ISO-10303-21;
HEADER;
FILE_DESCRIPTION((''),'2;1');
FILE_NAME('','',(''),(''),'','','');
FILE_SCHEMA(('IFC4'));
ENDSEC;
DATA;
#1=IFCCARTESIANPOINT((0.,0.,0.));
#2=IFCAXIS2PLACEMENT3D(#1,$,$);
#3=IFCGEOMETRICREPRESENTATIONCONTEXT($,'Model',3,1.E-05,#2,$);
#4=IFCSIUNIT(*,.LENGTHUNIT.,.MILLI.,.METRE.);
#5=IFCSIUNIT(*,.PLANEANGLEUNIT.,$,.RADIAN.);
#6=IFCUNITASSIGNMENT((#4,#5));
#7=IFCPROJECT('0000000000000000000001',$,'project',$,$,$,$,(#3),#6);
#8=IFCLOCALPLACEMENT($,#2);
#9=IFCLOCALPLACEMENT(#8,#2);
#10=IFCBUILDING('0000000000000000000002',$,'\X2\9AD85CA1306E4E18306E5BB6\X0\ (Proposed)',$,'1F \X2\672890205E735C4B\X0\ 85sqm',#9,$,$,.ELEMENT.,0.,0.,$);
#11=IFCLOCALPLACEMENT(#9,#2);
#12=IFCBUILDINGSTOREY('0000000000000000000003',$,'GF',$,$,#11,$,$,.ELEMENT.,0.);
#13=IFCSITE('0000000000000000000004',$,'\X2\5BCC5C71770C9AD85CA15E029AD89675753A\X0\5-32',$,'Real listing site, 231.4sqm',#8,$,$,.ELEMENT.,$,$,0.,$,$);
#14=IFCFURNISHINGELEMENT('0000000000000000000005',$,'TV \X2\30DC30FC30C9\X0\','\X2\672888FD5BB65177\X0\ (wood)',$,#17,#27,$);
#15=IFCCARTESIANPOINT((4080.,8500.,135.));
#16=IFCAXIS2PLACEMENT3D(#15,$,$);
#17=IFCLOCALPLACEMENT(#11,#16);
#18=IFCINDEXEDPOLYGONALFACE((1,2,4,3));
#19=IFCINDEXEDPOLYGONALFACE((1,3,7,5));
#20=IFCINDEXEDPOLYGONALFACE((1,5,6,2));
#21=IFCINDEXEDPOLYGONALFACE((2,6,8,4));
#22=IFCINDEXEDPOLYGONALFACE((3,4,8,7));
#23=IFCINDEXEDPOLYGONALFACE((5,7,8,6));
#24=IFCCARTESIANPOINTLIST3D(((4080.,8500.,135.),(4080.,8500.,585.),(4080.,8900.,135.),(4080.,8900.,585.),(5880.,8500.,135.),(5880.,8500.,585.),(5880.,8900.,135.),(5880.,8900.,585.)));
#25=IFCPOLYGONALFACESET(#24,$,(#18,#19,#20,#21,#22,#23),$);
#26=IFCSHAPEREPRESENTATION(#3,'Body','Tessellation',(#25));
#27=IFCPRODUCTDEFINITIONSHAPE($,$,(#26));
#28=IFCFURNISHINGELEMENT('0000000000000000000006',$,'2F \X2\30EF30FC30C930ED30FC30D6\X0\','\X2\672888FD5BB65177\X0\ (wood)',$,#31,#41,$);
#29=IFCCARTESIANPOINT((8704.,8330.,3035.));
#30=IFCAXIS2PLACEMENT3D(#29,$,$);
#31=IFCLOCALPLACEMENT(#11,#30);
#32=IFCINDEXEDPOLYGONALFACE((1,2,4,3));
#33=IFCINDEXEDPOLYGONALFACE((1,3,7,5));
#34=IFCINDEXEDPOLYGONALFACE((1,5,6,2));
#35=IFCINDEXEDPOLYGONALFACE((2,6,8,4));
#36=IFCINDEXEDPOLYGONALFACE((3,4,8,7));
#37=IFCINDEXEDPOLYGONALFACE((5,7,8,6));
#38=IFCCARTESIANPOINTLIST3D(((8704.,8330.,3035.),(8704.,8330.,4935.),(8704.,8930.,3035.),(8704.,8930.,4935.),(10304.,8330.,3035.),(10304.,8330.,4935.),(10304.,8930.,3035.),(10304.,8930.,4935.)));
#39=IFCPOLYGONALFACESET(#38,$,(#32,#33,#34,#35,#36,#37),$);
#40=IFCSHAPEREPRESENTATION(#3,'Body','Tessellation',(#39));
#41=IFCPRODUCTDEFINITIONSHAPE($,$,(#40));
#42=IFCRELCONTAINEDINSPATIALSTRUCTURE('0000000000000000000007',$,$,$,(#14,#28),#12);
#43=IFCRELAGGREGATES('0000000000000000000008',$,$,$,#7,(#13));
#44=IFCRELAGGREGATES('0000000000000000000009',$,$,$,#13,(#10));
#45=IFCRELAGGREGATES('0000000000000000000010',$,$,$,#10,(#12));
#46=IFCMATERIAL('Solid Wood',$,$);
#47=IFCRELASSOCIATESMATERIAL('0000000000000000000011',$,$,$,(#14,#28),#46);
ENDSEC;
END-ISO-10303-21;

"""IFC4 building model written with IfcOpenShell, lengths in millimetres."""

from ifc_helpers import new_model, si_unit, frame, frame_2d, origin, place, context, project, spatial, rectangle, extrude, material, element, save


model = new_model("IFC4")

# Units and contexts
model_context = context("Model", 3, precision=1e-05, world=origin())
ifc_project = project(units=[si_unit("LENGTHUNIT", "METRE", prefix="MILLI"), si_unit("PLANEANGLEUNIT", "RADIAN")], contexts=[model_context])

# Site, building, storey
site_placement = place(None, origin())
site = spatial("IfcSite", under=ifc_project, at=site_placement, Name="富山県高岡市高陵町5-32", ObjectType="Real listing site, 231.4sqm", CompositionType="ELEMENT", RefElevation=0.0)
building_placement = place(site_placement, origin())
building = spatial("IfcBuilding", under=site, at=building_placement, Name="高岡の丘の家 (Proposed)", ObjectType="1F 木造平屋 85sqm", CompositionType="ELEMENT", ElevationOfRefHeight=0.0, ElevationOfTerrain=0.0)
storey_placement = place(building_placement, origin())
storey = spatial("IfcBuildingStorey", under=building, at=storey_placement, Name="GF", CompositionType="ELEMENT", Elevation=0.0)

# Shared definitions
ifc_material_1 = material(Name="Solid Wood")

# Furnishing elements
furnishing_1_placement = place(storey_placement, frame((4080.0, 8500.0, 135.0)))
element("IfcFurnishingElement", 1, at=furnishing_1_placement, inside=storey, material=ifc_material_1, Name="TV ボード", Description="木製家具 (wood)", context=model_context, shape_type="SweptSolid", body=[
    extrude(rectangle(XDim=1800.0, YDim=400.0, at=frame_2d((900.0, 200.0))), frame((4080.0, 8500.0, 135.0)), (0.0, 0.0, 1.0), 450.0),
])
furnishing_2_placement = place(storey_placement, frame((8704.0, 8330.0, 3035.0)))
element("IfcFurnishingElement", 2, at=furnishing_2_placement, inside=storey, material=ifc_material_1, Name="2F ワードローブ", Description="木製家具 (wood)", context=model_context, shape_type="SweptSolid", body=[
    extrude(rectangle(XDim=1600.0, YDim=600.0, at=frame_2d((800.0, 300.0))), frame((8704.0, 8330.0, 3035.0)), (0.0, 0.0, 1.0), 1900.0),
])

save(model, "model.ifc")
